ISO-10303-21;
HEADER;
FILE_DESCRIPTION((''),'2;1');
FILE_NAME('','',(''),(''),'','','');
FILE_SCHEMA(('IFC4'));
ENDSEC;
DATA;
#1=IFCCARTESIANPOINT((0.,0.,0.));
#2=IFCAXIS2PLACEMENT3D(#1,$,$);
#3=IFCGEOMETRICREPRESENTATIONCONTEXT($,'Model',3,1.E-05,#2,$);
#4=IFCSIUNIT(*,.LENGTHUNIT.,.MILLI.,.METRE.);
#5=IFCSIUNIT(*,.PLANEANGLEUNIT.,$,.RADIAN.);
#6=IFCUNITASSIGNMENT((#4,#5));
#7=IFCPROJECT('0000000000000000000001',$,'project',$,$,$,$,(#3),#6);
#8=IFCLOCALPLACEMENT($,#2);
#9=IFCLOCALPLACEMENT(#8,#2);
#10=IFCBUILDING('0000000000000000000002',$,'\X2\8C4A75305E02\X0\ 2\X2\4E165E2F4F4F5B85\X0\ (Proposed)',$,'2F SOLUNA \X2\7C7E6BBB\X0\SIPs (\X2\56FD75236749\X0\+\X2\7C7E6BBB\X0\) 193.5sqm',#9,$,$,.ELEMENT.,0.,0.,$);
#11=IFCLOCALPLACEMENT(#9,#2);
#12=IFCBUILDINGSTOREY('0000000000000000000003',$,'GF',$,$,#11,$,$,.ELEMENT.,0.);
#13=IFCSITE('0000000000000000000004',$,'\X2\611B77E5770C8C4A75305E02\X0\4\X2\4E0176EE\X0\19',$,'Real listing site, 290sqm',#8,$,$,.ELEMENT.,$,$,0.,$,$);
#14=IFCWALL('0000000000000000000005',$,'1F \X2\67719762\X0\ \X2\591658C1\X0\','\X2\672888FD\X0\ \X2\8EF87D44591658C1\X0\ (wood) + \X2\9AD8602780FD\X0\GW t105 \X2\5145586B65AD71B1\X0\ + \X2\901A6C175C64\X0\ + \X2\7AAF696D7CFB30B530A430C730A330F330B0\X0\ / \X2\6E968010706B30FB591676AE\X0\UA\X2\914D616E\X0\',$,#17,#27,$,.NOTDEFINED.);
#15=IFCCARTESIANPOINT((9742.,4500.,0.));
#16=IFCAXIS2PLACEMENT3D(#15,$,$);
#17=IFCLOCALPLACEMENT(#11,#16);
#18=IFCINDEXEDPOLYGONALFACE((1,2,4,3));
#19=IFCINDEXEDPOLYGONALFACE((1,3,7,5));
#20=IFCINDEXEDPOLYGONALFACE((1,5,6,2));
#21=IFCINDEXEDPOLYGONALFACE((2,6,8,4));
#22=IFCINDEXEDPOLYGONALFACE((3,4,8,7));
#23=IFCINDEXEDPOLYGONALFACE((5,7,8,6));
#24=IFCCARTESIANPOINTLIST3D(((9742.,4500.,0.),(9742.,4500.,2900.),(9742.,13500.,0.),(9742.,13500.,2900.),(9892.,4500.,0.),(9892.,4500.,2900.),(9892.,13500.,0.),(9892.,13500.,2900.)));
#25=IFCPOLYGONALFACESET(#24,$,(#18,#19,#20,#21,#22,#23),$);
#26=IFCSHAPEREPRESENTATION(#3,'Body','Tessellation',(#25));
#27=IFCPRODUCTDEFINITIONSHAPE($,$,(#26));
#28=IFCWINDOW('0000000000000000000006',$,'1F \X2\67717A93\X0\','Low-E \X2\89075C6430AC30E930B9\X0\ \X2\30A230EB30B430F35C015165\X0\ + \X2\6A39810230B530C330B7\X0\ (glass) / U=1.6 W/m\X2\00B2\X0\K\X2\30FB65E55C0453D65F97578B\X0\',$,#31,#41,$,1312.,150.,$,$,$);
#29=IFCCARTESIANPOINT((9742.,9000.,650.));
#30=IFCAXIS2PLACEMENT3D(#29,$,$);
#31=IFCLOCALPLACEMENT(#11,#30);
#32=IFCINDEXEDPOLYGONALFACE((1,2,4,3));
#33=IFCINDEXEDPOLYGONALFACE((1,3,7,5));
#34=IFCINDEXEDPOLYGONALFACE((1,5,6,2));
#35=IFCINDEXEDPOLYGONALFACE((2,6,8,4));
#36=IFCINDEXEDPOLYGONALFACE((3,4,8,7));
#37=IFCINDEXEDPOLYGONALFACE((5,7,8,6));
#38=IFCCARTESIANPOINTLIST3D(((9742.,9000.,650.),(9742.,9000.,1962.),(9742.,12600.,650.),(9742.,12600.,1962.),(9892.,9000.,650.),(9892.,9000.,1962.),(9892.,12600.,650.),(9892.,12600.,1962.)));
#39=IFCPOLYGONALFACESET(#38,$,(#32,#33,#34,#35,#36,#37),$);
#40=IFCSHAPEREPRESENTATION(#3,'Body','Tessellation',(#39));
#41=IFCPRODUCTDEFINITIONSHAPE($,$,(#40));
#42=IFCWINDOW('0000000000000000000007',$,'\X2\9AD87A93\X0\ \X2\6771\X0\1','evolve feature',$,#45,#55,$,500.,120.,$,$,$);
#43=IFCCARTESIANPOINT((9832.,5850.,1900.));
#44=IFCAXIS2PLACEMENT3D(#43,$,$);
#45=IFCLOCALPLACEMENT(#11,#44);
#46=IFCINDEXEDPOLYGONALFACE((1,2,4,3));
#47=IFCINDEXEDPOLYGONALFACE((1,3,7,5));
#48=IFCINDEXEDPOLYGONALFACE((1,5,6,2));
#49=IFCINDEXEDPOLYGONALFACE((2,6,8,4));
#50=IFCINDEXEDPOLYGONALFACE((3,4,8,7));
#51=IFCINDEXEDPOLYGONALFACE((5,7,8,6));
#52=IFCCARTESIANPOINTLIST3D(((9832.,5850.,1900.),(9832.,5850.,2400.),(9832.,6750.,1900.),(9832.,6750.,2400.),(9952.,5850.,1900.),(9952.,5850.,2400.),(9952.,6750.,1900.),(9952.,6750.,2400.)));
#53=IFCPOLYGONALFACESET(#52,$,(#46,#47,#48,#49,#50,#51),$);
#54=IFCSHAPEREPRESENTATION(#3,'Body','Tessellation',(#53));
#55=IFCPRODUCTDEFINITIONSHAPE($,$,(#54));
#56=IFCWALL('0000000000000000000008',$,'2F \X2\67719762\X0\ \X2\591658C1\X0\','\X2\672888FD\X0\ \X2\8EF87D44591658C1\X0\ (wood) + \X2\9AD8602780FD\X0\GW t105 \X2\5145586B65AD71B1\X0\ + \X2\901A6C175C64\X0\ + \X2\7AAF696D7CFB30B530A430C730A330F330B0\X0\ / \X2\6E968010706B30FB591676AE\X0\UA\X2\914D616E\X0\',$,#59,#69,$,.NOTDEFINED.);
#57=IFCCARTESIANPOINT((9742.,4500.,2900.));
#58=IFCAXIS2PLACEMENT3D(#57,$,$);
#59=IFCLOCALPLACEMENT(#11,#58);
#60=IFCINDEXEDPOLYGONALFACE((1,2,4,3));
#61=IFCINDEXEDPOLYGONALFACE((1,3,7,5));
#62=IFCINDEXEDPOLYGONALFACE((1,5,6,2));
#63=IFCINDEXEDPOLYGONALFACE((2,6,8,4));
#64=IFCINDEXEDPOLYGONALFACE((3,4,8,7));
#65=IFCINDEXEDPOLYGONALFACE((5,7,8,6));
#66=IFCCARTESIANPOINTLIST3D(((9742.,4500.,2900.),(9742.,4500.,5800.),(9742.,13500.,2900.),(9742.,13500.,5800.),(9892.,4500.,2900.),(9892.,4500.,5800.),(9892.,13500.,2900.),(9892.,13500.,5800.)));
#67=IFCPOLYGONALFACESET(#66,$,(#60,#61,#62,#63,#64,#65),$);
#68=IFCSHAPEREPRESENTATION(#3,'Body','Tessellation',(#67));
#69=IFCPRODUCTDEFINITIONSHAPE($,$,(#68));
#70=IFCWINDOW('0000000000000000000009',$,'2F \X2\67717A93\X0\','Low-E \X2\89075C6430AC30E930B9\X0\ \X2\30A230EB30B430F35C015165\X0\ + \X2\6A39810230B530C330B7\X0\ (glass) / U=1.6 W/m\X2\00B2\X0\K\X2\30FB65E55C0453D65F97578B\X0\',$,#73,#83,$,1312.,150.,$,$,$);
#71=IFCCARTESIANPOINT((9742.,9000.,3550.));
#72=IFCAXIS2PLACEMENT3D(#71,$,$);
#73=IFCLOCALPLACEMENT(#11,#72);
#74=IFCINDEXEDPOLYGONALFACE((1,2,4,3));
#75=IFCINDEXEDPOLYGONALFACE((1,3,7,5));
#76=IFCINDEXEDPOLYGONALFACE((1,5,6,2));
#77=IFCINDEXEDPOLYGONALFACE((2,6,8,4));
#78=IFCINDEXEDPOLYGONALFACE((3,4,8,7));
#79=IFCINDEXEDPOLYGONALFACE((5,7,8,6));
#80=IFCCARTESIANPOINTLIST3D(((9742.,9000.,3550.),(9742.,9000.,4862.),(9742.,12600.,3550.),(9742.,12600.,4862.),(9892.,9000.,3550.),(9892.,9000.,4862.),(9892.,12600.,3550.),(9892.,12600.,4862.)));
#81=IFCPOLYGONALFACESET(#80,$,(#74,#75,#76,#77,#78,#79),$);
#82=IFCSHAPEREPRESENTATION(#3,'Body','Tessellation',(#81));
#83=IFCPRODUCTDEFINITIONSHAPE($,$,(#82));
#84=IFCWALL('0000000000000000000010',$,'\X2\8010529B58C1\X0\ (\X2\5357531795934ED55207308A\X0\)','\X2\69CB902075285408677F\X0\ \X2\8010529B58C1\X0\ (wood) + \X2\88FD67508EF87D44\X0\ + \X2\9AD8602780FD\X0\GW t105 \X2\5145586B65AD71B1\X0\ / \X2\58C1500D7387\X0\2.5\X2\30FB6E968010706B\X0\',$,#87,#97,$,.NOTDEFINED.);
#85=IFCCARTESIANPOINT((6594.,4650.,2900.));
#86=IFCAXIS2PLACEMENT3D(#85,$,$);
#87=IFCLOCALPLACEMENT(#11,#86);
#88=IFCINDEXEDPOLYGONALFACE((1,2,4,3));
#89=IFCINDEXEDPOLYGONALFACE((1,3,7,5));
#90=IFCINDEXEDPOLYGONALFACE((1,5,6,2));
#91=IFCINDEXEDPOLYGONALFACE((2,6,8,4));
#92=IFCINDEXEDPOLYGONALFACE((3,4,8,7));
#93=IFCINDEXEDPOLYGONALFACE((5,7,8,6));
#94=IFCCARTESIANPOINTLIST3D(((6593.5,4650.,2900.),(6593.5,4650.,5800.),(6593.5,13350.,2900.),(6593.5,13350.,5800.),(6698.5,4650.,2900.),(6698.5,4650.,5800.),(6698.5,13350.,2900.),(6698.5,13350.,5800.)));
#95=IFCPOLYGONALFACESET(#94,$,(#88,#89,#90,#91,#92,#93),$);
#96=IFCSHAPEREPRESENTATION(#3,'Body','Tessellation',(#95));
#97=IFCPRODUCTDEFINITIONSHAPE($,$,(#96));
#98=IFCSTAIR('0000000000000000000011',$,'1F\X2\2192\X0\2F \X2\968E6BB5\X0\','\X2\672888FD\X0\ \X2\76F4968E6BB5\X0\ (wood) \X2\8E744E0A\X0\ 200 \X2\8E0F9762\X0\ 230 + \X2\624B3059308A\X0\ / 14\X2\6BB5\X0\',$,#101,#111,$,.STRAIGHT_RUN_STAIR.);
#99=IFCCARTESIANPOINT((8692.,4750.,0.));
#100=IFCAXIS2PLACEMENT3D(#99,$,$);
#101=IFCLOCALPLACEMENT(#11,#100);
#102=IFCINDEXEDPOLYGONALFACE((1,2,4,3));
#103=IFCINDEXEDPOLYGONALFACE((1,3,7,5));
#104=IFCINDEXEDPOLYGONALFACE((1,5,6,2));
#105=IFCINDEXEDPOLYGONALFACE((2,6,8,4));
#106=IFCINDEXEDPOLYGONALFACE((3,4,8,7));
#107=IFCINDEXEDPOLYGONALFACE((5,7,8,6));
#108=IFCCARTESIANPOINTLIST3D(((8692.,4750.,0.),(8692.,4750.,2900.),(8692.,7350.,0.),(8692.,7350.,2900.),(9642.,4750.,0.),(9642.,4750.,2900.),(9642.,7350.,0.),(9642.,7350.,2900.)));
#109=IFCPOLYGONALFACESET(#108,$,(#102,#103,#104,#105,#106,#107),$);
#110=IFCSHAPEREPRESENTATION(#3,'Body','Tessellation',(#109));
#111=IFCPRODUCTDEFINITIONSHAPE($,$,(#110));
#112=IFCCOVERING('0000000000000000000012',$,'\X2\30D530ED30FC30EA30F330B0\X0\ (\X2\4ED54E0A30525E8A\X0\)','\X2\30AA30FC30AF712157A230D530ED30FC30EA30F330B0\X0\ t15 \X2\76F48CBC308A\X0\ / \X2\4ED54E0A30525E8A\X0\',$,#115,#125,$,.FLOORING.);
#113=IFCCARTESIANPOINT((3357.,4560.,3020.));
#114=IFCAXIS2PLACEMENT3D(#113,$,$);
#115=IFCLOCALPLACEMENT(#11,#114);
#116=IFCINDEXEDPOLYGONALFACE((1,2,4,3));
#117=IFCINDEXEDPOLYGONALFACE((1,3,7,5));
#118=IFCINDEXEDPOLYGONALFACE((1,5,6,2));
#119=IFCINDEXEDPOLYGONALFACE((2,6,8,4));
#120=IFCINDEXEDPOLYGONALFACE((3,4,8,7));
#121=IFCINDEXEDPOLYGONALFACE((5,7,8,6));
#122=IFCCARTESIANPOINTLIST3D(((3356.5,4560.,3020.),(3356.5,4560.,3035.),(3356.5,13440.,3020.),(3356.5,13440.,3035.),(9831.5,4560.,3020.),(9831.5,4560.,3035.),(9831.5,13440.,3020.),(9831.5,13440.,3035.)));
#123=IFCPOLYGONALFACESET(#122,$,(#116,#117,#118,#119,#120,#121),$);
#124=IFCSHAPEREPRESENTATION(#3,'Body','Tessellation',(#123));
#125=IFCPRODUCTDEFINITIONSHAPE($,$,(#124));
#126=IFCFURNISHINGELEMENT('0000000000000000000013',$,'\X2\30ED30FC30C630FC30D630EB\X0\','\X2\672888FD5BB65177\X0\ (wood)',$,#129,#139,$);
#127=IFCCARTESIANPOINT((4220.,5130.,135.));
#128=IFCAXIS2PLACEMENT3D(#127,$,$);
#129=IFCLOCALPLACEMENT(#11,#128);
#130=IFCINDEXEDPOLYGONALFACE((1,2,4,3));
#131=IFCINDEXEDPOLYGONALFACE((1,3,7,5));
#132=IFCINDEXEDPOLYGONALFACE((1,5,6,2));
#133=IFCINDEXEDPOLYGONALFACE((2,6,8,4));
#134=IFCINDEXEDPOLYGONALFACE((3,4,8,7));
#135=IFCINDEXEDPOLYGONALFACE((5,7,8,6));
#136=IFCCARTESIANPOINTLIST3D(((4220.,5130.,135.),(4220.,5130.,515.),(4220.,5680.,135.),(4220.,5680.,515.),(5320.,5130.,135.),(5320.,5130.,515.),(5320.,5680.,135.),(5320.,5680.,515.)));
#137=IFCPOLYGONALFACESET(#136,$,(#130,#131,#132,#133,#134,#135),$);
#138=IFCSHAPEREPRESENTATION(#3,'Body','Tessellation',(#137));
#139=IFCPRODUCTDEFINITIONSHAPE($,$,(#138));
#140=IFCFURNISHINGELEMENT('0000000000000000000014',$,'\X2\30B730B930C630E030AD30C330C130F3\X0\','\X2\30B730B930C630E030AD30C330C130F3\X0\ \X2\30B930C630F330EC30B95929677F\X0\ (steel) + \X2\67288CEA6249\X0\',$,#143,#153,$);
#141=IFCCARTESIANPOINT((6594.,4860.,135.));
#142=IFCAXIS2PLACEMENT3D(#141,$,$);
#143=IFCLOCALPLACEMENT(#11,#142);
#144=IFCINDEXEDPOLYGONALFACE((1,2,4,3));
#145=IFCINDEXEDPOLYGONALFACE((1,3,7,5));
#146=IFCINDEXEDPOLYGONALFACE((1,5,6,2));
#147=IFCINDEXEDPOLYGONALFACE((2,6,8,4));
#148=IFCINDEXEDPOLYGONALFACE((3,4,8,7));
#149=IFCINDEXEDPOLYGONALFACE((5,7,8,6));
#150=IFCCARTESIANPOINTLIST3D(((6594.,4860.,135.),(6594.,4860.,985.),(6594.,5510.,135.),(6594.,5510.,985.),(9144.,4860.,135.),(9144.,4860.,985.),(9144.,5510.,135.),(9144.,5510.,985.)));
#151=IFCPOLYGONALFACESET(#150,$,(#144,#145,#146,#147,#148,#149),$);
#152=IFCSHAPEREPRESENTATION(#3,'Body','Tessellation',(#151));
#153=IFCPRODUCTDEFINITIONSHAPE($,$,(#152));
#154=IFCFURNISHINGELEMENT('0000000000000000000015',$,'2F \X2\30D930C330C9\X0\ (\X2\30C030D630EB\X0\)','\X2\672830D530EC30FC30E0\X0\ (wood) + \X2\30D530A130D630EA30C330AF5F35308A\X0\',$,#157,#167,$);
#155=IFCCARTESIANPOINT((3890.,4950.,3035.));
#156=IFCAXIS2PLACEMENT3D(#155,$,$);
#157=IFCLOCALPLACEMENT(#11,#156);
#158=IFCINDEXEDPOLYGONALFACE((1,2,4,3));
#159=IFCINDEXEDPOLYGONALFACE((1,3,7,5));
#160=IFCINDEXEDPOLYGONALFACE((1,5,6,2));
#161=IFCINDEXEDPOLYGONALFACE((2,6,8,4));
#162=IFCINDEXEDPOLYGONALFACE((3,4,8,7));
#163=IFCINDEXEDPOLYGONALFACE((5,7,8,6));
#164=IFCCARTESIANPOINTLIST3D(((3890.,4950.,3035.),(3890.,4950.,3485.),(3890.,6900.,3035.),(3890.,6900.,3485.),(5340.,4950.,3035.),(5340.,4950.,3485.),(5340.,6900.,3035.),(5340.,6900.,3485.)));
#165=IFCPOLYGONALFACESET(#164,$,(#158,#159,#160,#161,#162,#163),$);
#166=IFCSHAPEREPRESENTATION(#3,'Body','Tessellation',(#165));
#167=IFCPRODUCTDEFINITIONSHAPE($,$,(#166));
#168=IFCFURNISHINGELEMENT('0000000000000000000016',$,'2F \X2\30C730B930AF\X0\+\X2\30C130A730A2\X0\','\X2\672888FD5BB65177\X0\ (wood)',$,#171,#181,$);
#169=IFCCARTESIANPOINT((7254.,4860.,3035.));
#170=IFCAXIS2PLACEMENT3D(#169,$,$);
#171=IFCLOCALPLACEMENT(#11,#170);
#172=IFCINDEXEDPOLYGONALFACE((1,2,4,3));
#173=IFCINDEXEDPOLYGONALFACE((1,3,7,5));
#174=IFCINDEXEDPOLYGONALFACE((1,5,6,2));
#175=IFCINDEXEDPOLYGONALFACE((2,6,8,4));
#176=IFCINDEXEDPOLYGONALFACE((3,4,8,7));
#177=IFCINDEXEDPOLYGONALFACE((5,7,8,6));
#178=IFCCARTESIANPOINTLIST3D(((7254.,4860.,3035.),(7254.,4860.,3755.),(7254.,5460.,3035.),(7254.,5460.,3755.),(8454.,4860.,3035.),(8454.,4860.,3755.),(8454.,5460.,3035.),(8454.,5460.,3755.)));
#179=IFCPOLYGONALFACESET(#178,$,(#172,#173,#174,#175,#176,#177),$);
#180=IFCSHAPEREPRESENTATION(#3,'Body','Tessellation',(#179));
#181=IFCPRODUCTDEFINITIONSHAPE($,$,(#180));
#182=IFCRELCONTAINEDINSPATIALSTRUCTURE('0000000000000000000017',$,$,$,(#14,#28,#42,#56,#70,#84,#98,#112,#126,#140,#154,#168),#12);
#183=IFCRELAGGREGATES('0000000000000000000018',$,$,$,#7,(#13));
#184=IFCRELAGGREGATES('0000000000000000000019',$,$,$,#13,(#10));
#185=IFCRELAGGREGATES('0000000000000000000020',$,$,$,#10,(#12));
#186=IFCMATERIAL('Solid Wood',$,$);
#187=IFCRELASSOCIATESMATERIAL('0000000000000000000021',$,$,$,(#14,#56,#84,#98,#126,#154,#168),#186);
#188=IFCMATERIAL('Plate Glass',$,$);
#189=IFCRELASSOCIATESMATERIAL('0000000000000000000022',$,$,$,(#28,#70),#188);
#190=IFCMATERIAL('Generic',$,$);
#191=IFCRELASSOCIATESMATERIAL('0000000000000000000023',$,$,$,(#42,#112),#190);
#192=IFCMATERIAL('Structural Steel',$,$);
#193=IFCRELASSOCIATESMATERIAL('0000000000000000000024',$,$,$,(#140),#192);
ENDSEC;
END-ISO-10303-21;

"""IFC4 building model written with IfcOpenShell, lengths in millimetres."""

from ifc_helpers import new_model, si_unit, frame, frame_2d, origin, place, context, project, spatial, rectangle, extrude, material, element, fill, save


model = new_model("IFC4")

# Units and contexts
model_context = context("Model", 3, precision=1e-05, world=origin())
ifc_project = project(units=[si_unit("LENGTHUNIT", "METRE", prefix="MILLI"), si_unit("PLANEANGLEUNIT", "RADIAN")], contexts=[model_context])

# Site, building, storey
site_placement = place(None, origin())
site = spatial("IfcSite", under=ifc_project, at=site_placement, Name="愛知県豊田市4丁目19", ObjectType="Real listing site, 290sqm", CompositionType="ELEMENT", RefElevation=0.0)
building_placement = place(site_placement, origin())
building = spatial("IfcBuilding", under=site, at=building_placement, Name="豊田市 2世帯住宅 (Proposed)", ObjectType="2F SOLUNA 籾殻SIPs (国産杉+籾殻) 193.5sqm", CompositionType="ELEMENT", ElevationOfRefHeight=0.0, ElevationOfTerrain=0.0)
storey_placement = place(building_placement, origin())
storey = spatial("IfcBuildingStorey", under=building, at=storey_placement, Name="GF", CompositionType="ELEMENT", Elevation=0.0)

# Shared definitions
ifc_material_1 = material(Name="Solid Wood")

# Wall, openings, windows
wall_1_placement = place(storey_placement, frame((9742.0, 4500.0, 0.0)))
wall_1 = element("IfcWall", 1, at=wall_1_placement, inside=storey, material=ifc_material_1, Name="1F 東面 外壁", Description="木製 軸組外壁 (wood) + 高性能GW t105 充填断熱 + 通気層 + 窯業系サイディング / 準耐火・外皮UA配慮", PredefinedType="NOTDEFINED", context=model_context, shape_type="SweptSolid", body=[
    extrude(rectangle(XDim=150.0, YDim=9000.0, at=frame_2d((75.0, 4500.0))), frame((9742.0, 4500.0, 0.0)), (0.0, 0.0, 1.0), 2900.0),
])
opening_1_placement = place(storey_placement, frame((9742.0, 9000.0, 650.0)))
opening_1 = element("IfcOpeningElement", 2, at=opening_1_placement, cuts=wall_1, PredefinedType="NOTDEFINED", context=model_context, shape_type="SweptSolid", body=[
    extrude(rectangle(XDim=150.0, YDim=3600.0, at=frame_2d((75.0, 1800.0))), frame((9742.0, 9000.0, 650.0)), (0.0, 0.0, 1.0), 1312.0),
])
opening_2_placement = place(storey_placement, frame((9832.0, 5850.0, 1900.0)))
opening_2 = element("IfcOpeningElement", 3, at=opening_2_placement, cuts=wall_1, PredefinedType="NOTDEFINED", context=model_context, shape_type="SweptSolid", body=[
    extrude(rectangle(XDim=120.0, YDim=900.0, at=frame_2d((60.0, 450.0))), frame((9832.0, 5850.0, 1900.0)), (0.0, 0.0, 1.0), 500.0),
])
ifc_material_2 = material(Name="Plate Glass")
window_1_placement = place(storey_placement, frame((9742.0, 9000.0, 650.0)))
window_1 = element("IfcWindow", 4, at=window_1_placement, inside=storey, material=ifc_material_2, Name="1F 東窓", Description="Low-E 複層ガラス アルゴン封入 + 樹脂サッシ (glass) / U=1.6 W/m²K・日射取得型", OverallHeight=1312.0, OverallWidth=150.0, context=model_context, shape_type="SweptSolid", body=[
    extrude(rectangle(XDim=150.0, YDim=3600.0, at=frame_2d((75.0, 1800.0))), frame((9742.0, 9000.0, 650.0)), (0.0, 0.0, 1.0), 1312.0),
])
fill(opening_1, window_1)
ifc_material_3 = material(Name="Generic")
window_2_placement = place(storey_placement, frame((9832.0, 5850.0, 1900.0)))
window_2 = element("IfcWindow", 5, at=window_2_placement, inside=storey, material=ifc_material_3, Name="高窓 東1", Description="evolve feature", OverallHeight=500.0, OverallWidth=120.0, context=model_context, shape_type="SweptSolid", body=[
    extrude(rectangle(XDim=120.0, YDim=900.0, at=frame_2d((60.0, 450.0))), frame((9832.0, 5850.0, 1900.0)), (0.0, 0.0, 1.0), 500.0),
])
fill(opening_2, window_2)

# Wall, opening, window
wall_2_placement = place(storey_placement, frame((9742.0, 4500.0, 2900.0)))
wall_2 = element("IfcWall", 6, at=wall_2_placement, inside=storey, material=ifc_material_1, Name="2F 東面 外壁", Description="木製 軸組外壁 (wood) + 高性能GW t105 充填断熱 + 通気層 + 窯業系サイディング / 準耐火・外皮UA配慮", PredefinedType="NOTDEFINED", context=model_context, shape_type="SweptSolid", body=[
    extrude(rectangle(XDim=150.0, YDim=9000.0, at=frame_2d((75.0, 4500.0))), frame((9742.0, 4500.0, 2900.0)), (0.0, 0.0, 1.0), 2900.0),
])
opening_3_placement = place(storey_placement, frame((9742.0, 9000.0, 3550.0)))
opening_3 = element("IfcOpeningElement", 7, at=opening_3_placement, cuts=wall_2, PredefinedType="NOTDEFINED", context=model_context, shape_type="SweptSolid", body=[
    extrude(rectangle(XDim=150.0, YDim=3600.0, at=frame_2d((75.0, 1800.0))), frame((9742.0, 9000.0, 3550.0)), (0.0, 0.0, 1.0), 1312.0),
])
window_3_placement = place(storey_placement, frame((9742.0, 9000.0, 3550.0)))
window_3 = element("IfcWindow", 8, at=window_3_placement, inside=storey, material=ifc_material_2, Name="2F 東窓", Description="Low-E 複層ガラス アルゴン封入 + 樹脂サッシ (glass) / U=1.6 W/m²K・日射取得型", OverallHeight=1312.0, OverallWidth=150.0, context=model_context, shape_type="SweptSolid", body=[
    extrude(rectangle(XDim=150.0, YDim=3600.0, at=frame_2d((75.0, 1800.0))), frame((9742.0, 9000.0, 3550.0)), (0.0, 0.0, 1.0), 1312.0),
])
fill(opening_3, window_3)

# Wall
wall_3_placement = place(storey_placement, frame((6594.0, 4650.0, 2900.0)))
element("IfcWall", 9, at=wall_3_placement, inside=storey, material=ifc_material_1, Name="耐力壁 (南北間仕切り)", Description="構造用合板 耐力壁 (wood) + 製材軸組 + 高性能GW t105 充填断熱 / 壁倍率2.5・準耐火", PredefinedType="NOTDEFINED", context=model_context, shape_type="SweptSolid", body=[
    extrude(rectangle(XDim=105.0, YDim=8700.0, at=frame_2d((52.0, 4350.0))), frame((6594.0, 4650.0, 2900.0)), (0.0, 0.0, 1.0), 2900.0),
])

# Stair
stair_placement = place(storey_placement, frame((8692.0, 4750.0, 0.0)))
element("IfcStair", 10, at=stair_placement, inside=storey, material=ifc_material_1, Name="1F→2F 階段", Description="木製 直階段 (wood) 蹴上 200 踏面 230 + 手すり / 14段", PredefinedType="STRAIGHT_RUN_STAIR", context=model_context, shape_type="SweptSolid", body=[
    extrude(rectangle(XDim=950.0, YDim=2600.0, at=frame_2d((475.0, 1300.0))), frame((8692.0, 4750.0, 0.0)), (0.0, 0.0, 1.0), 2900.0),
])

# Covering
covering_placement = place(storey_placement, frame((3357.0, 4560.0, 3020.0)))
element("IfcCovering", 11, at=covering_placement, inside=storey, material=ifc_material_3, Name="フローリング (仕上げ床)", Description="オーク無垢フローリング t15 直貼り / 仕上げ床", PredefinedType="FLOORING", context=model_context, shape_type="SweptSolid", body=[
    extrude(rectangle(XDim=6475.0, YDim=8880.0, at=frame_2d((3237.0, 4440.0))), frame((3357.0, 4560.0, 3020.0)), (0.0, 0.0, 1.0), 15.0),
])

# Furnishing elements
furnishing_1_placement = place(storey_placement, frame((4220.0, 5130.0, 135.0)))
element("IfcFurnishingElement", 12, at=furnishing_1_placement, inside=storey, material=ifc_material_1, Name="ローテーブル", Description="木製家具 (wood)", context=model_context, shape_type="SweptSolid", body=[
    extrude(rectangle(XDim=1100.0, YDim=550.0, at=frame_2d((550.0, 275.0))), frame((4220.0, 5130.0, 135.0)), (0.0, 0.0, 1.0), 380.0),
])
ifc_material_4 = material(Name="Structural Steel")
furnishing_2_placement = place(storey_placement, frame((6594.0, 4860.0, 135.0)))
element("IfcFurnishingElement", 13, at=furnishing_2_placement, inside=storey, material=ifc_material_4, Name="システムキッチン", Description="システムキッチン ステンレス天板 (steel) + 木質扉", context=model_context, shape_type="SweptSolid", body=[
    extrude(rectangle(XDim=2550.0, YDim=650.0, at=frame_2d((1275.0, 325.0))), frame((6594.0, 4860.0, 135.0)), (0.0, 0.0, 1.0), 850.0),
])
furnishing_3_placement = place(storey_placement, frame((3890.0, 4950.0, 3035.0)))
element("IfcFurnishingElement", 14, at=furnishing_3_placement, inside=storey, material=ifc_material_1, Name="2F ベッド (ダブル)", Description="木フレーム (wood) + ファブリック張り", context=model_context, shape_type="SweptSolid", body=[
    extrude(rectangle(XDim=1450.0, YDim=1950.0, at=frame_2d((725.0, 975.0))), frame((3890.0, 4950.0, 3035.0)), (0.0, 0.0, 1.0), 450.0),
])
furnishing_4_placement = place(storey_placement, frame((7254.0, 4860.0, 3035.0)))
element("IfcFurnishingElement", 15, at=furnishing_4_placement, inside=storey, material=ifc_material_1, Name="2F デスク+チェア", Description="木製家具 (wood)", context=model_context, shape_type="SweptSolid", body=[
    extrude(rectangle(XDim=1200.0, YDim=600.0, at=frame_2d((600.0, 300.0))), frame((7254.0, 4860.0, 3035.0)), (0.0, 0.0, 1.0), 720.0),
])

save(model, "model.ifc")
